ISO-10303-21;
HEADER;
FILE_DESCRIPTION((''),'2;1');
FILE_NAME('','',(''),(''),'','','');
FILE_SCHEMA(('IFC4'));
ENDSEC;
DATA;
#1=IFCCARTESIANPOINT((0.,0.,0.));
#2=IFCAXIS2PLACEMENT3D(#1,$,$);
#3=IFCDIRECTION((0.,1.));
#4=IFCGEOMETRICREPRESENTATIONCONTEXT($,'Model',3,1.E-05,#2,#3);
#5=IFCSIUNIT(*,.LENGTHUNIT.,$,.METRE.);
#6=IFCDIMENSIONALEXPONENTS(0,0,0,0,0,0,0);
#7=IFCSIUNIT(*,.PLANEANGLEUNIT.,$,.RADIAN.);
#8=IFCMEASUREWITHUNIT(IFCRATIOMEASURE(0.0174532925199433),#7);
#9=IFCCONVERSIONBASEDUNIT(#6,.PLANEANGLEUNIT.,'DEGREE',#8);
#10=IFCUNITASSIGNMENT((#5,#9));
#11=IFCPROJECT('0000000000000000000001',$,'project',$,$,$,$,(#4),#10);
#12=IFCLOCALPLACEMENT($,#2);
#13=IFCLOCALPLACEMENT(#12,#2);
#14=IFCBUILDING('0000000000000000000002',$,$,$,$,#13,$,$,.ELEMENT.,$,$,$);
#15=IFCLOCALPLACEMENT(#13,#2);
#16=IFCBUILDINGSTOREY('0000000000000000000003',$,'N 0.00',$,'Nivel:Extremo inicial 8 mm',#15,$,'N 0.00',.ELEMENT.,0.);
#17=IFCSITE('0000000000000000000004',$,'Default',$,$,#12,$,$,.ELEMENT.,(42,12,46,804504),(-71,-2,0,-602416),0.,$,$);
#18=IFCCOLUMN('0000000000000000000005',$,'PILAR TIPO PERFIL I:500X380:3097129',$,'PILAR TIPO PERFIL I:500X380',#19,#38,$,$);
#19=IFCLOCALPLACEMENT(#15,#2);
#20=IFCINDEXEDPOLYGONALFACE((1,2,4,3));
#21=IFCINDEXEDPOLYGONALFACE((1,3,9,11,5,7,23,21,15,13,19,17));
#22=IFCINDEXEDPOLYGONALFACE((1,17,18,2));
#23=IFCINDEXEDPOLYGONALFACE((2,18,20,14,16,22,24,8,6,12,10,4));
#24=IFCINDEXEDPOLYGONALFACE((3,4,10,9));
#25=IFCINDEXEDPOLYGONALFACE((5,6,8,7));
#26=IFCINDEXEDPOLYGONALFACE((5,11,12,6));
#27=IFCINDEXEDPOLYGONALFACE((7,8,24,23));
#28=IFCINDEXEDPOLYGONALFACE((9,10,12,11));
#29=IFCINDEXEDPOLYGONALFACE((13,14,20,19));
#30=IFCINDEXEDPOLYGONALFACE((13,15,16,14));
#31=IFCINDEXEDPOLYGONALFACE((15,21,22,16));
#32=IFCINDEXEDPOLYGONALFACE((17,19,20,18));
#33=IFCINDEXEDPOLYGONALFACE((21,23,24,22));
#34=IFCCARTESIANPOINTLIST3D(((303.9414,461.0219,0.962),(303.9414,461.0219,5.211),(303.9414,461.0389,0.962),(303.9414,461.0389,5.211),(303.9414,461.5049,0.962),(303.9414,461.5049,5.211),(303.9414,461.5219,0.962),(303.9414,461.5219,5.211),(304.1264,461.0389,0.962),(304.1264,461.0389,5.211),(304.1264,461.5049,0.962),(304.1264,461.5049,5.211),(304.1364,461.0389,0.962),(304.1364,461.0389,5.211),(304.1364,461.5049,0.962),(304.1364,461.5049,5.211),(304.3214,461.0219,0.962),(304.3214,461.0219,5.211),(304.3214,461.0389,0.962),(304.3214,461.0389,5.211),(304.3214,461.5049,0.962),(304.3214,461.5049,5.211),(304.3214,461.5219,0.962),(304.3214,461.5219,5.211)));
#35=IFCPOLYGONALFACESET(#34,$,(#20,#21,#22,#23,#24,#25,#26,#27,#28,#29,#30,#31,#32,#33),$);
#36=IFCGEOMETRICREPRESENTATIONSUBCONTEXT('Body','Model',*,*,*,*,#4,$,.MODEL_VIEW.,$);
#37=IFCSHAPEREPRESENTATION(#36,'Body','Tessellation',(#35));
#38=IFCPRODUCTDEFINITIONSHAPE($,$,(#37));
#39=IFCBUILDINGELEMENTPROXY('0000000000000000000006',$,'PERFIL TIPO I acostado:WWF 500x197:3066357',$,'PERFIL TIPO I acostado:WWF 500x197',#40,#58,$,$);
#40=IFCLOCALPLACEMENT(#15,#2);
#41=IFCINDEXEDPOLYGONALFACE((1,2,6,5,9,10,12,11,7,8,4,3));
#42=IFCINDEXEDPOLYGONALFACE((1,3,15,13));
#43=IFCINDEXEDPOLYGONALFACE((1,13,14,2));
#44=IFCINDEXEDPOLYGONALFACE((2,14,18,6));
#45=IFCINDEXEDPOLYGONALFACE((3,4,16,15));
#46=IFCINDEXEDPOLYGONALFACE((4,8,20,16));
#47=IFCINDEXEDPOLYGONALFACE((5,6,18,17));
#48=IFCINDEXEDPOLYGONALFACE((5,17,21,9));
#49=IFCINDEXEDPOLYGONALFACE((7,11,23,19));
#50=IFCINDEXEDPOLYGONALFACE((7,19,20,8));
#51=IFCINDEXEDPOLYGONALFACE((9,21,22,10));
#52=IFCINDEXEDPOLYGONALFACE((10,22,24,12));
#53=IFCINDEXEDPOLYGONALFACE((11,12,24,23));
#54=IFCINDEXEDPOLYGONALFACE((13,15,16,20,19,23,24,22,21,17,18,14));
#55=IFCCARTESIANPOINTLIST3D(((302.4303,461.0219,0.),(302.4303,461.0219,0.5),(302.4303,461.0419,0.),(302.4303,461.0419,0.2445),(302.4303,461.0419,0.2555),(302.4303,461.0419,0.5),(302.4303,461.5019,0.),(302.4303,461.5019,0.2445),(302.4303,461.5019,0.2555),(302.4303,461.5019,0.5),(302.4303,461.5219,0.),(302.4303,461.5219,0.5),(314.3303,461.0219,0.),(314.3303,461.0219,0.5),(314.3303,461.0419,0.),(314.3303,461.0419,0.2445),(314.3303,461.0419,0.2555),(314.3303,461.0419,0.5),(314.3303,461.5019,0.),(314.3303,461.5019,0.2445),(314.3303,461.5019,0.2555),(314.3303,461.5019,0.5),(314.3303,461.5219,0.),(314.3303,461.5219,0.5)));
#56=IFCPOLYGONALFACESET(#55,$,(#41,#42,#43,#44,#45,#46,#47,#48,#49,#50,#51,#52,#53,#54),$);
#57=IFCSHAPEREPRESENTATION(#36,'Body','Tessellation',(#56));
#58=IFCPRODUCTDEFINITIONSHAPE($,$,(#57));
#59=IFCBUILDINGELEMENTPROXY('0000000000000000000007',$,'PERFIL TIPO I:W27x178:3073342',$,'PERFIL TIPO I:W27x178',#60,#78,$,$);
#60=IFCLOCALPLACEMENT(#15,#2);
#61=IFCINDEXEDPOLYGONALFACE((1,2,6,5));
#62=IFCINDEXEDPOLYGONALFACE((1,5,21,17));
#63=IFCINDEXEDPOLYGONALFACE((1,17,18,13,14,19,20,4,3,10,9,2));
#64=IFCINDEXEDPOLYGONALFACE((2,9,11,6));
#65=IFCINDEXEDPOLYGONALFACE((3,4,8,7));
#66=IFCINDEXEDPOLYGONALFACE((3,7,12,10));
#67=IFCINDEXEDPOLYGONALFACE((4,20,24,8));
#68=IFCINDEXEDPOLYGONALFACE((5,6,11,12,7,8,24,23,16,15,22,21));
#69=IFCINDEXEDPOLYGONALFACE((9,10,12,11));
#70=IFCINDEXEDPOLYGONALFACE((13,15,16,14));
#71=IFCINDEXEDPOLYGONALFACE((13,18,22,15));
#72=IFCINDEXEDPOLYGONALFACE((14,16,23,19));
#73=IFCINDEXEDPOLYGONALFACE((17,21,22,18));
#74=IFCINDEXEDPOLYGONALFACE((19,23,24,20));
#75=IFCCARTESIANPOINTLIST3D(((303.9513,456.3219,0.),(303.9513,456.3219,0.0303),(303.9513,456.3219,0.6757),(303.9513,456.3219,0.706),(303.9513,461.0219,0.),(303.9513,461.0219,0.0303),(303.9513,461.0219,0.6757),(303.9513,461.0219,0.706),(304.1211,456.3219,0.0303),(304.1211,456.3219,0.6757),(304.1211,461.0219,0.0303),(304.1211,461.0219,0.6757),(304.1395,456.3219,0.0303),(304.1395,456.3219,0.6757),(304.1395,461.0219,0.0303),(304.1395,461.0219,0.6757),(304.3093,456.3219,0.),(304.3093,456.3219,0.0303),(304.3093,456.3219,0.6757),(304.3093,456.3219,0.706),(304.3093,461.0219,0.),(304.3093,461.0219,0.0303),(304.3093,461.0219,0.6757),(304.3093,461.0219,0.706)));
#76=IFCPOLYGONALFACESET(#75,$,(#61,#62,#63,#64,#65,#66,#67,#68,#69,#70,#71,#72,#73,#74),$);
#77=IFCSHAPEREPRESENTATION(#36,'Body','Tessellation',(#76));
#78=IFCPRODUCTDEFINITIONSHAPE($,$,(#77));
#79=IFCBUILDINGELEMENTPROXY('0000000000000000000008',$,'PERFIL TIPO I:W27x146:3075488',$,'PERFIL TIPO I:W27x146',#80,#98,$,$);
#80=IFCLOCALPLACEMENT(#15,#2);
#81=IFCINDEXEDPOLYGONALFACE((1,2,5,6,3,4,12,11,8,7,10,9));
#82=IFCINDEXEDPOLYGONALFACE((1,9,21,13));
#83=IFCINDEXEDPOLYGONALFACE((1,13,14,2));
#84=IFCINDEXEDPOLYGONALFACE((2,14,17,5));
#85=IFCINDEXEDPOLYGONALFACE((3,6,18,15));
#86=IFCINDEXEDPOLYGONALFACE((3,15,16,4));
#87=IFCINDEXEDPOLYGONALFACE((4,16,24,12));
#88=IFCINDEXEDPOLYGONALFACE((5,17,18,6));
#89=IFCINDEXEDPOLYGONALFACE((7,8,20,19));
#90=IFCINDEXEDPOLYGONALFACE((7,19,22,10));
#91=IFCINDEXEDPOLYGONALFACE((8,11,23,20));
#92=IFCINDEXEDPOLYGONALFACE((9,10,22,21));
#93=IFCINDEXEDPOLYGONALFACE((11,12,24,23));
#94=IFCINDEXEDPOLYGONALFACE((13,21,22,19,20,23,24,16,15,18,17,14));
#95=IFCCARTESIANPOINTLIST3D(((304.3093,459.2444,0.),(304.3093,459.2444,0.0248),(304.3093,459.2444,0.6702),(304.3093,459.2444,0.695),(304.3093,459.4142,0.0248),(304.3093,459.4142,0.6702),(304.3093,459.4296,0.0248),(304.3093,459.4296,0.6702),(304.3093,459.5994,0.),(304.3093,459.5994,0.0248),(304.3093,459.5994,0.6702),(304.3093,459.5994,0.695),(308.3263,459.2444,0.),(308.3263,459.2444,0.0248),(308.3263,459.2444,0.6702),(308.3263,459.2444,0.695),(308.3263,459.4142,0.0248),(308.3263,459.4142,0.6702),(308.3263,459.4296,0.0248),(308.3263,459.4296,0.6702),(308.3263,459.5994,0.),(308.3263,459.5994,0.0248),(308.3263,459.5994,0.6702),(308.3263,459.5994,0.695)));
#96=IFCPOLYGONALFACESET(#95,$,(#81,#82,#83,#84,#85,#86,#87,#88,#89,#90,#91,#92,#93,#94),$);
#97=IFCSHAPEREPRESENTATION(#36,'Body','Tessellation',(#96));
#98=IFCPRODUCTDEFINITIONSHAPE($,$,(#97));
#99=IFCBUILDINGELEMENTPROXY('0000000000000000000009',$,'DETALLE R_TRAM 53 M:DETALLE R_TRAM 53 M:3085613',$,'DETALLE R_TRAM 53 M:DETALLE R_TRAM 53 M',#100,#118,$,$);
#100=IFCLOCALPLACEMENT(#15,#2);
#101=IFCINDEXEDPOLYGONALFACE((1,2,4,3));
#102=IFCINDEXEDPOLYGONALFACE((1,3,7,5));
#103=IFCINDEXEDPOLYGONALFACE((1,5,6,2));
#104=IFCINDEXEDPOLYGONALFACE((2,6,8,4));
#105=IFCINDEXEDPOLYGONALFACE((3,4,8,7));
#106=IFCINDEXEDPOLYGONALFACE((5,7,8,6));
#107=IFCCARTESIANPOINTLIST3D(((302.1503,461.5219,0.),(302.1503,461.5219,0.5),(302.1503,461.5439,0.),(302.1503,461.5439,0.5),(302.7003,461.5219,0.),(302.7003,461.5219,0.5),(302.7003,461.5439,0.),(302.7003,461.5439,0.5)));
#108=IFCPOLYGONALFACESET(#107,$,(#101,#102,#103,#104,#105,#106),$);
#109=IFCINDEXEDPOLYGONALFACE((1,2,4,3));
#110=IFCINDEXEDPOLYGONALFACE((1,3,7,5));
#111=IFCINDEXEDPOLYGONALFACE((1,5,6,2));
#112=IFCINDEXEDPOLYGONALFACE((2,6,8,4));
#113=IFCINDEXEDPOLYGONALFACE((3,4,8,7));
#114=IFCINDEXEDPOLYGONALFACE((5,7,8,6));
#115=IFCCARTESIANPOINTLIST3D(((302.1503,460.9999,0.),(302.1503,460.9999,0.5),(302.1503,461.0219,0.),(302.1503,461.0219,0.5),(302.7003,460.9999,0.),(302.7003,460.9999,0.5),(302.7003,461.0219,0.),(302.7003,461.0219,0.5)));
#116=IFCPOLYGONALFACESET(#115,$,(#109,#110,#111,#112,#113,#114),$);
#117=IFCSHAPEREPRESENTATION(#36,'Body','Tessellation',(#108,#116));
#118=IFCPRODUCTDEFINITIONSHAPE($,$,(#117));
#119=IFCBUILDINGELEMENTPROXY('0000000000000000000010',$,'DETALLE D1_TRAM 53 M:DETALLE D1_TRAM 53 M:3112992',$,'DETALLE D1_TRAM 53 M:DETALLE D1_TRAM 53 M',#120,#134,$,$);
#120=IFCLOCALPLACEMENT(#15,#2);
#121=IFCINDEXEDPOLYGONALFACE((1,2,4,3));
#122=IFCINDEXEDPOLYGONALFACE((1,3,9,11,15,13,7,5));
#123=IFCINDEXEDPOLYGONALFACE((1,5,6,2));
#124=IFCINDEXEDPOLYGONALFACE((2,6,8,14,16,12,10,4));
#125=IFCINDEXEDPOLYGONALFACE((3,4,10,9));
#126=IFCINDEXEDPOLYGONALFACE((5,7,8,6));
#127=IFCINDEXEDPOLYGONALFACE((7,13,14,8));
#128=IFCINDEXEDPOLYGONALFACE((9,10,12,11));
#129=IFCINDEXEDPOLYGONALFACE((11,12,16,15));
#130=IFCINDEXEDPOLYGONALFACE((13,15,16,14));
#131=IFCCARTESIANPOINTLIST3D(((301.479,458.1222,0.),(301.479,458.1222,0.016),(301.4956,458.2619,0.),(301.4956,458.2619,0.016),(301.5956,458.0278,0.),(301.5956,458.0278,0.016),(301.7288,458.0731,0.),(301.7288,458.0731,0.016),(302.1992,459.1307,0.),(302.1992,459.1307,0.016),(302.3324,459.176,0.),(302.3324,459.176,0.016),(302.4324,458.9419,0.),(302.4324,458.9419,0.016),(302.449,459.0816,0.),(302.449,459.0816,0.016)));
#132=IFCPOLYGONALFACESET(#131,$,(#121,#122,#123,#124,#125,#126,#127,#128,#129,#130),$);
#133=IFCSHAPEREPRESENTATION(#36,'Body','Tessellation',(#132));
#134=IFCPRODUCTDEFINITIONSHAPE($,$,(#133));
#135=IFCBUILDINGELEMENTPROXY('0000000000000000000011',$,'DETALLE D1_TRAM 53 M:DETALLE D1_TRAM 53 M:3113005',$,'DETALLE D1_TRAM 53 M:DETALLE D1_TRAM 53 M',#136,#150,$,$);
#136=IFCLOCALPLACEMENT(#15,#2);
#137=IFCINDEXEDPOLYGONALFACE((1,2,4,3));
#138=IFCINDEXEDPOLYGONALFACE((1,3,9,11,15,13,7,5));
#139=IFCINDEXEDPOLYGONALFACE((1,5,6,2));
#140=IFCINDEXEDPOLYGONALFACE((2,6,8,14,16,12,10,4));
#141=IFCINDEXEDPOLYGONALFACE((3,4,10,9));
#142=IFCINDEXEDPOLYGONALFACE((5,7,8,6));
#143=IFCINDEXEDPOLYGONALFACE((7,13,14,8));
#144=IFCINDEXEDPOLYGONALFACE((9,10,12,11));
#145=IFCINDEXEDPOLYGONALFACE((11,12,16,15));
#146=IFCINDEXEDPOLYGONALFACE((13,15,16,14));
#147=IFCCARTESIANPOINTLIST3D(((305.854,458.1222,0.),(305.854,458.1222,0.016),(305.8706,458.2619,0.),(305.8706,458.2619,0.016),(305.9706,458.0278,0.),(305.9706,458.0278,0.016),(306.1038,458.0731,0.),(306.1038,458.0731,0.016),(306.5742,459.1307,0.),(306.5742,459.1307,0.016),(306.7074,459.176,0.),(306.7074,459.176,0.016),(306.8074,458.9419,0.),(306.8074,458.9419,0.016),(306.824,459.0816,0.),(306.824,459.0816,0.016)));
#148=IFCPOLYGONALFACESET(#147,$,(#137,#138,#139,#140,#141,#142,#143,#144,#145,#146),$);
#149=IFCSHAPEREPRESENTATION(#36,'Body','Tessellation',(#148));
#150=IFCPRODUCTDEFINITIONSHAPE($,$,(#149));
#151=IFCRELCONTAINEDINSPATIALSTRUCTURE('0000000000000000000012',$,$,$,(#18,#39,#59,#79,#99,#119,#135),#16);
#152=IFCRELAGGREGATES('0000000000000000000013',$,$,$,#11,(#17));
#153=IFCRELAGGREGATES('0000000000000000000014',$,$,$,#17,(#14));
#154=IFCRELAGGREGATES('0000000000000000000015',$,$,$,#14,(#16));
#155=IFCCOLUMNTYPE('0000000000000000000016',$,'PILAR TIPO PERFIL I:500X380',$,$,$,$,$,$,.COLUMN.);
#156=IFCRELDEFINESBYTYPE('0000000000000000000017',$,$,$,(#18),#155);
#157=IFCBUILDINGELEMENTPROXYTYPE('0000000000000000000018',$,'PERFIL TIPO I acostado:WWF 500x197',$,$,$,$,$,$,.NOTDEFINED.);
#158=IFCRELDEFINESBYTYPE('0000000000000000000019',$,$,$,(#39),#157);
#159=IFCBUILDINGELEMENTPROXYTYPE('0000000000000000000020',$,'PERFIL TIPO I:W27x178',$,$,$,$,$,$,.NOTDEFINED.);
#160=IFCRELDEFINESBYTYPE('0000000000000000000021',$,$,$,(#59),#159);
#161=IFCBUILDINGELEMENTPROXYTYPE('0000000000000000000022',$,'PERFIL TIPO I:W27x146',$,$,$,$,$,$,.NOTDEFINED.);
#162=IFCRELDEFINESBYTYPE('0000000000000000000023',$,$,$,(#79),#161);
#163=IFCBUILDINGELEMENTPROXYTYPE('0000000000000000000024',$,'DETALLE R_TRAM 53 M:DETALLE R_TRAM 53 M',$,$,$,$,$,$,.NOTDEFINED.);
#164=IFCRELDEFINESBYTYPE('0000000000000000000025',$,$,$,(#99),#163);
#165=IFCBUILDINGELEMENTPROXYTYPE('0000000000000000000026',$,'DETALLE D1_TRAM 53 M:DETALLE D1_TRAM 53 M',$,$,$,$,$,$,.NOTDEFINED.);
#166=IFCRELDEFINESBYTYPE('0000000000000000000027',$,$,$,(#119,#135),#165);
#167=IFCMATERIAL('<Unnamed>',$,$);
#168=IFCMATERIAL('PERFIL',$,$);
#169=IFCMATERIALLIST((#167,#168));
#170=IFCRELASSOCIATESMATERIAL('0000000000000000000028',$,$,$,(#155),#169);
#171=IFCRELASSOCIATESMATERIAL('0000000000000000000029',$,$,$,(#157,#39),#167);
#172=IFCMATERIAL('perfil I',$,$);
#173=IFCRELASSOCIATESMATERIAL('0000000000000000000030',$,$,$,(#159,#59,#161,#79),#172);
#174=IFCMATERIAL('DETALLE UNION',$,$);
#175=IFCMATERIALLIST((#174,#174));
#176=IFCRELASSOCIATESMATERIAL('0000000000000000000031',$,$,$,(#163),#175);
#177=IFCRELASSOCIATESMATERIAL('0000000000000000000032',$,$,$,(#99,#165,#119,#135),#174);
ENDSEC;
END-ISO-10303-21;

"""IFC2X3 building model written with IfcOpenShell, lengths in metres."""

from ifc_helpers import new_model, entity, si_unit, converted_unit, direction, frame, frame_2d, origin, place, context, subcontext, project, spatial, polyline, rectangle, i_section, outline, extrude, source, transform, mapped, material, material_list, type_object, type_shapes, element, save


model = new_model("IFC2X3")

# Units and contexts
model_context = context("Model", 3, precision=1e-05, world=origin(), true_north=direction((0.0, 1.0)))
body_context = subcontext(model_context, "Body", "Model", "MODEL_VIEW")
ifc_project = project(units=[si_unit("LENGTHUNIT", "METRE"), converted_unit("PLANEANGLEUNIT", "DEGREE", entity("IfcRatioMeasure", 0.0174532925199433), si_unit("PLANEANGLEUNIT", "RADIAN"), dimensions=[0, 0, 0, 0, 0, 0, 0])], contexts=[model_context])

# Site, building, storey
site_placement = place(None, origin())
site = spatial("IfcSite", under=ifc_project, at=site_placement, Name="Default", CompositionType="ELEMENT", RefLatitude=(42, 12, 46, 804504), RefLongitude=(-71, -2, 0, -602416), RefElevation=0.0)
building_placement = place(site_placement, origin())
building = spatial("IfcBuilding", under=site, at=building_placement, CompositionType="ELEMENT")
storey_placement = place(building_placement, origin())
storey = spatial("IfcBuildingStorey", under=building, at=storey_placement, Name="N 0.00", ObjectType="Nivel:Extremo inicial 8 mm", LongName="N 0.00", CompositionType="ELEMENT", Elevation=0.0)

# Column
ifc_material_1 = material(Name="<Unnamed>")
ifc_material_2 = material(Name="PERFIL")
ifc_material_list_1 = material_list([ifc_material_1, ifc_material_2])
column_type = type_object("IfcColumnType", Name="PILAR TIPO PERFIL I:500X380", PredefinedType="COLUMN", material=ifc_material_list_1)
shared_shape_1 = source(origin(), body_context, "Body", "SweptSolid", [
    extrude(i_section(OverallWidth=0.38, OverallDepth=0.5, WebThickness=0.01, FlangeThickness=0.017, at=frame_2d((0.0, 0.0), x_axis=(1.0, 0.0))), frame((0.0, 0.0, 0.962), z_axis=(0.0, 0.0, 1.0), x_axis=(0.0, -1.0, 0.0)), (0.0, 0.0, 1.0), 4.249),
])
type_shapes(column_type, [shared_shape_1])
column_placement = place(storey_placement, frame((304.1314, 461.2719, 0.0), z_axis=(0.0, 0.0, 1.0), x_axis=(0.0, -1.0, 0.0)))
element("IfcColumn", 1, at=column_placement, inside=storey, type_object=column_type, Name="PILAR TIPO PERFIL I:500X380:3097129", ObjectType="PILAR TIPO PERFIL I:500X380", context=body_context, shape_type="MappedRepresentation", body=[
    mapped(shared_shape_1, transform((0.0, 0.0, 0.0), scale=1.0)),
])

# Building element proxies
building_element_proxy_type_1 = type_object("IfcBuildingElementProxyType", Name="PERFIL TIPO I acostado:WWF 500x197", PredefinedType="NOTDEFINED", material=ifc_material_1)
shared_shape_2 = source(origin(), body_context, "Body", "SweptSolid", [
    extrude(outline(polyline([(-0.25, -0.23), (-0.25, -0.25), (0.25, -0.25), (0.25, -0.23), (0.0055, -0.23), (0.0055, 0.23), (0.25, 0.23), (0.25, 0.25), (-0.25, 0.25), (-0.25, 0.23), (-0.0055, 0.23), (-0.0055, -0.23), (-0.25, -0.23)])), frame((0.0, 0.0, 0.25), z_axis=(-1.0, 0.0, 0.0), x_axis=(0.0, 0.0, -1.0)), (0.0, 0.0, -1.0), 11.9),
])
type_shapes(building_element_proxy_type_1, [shared_shape_2])
proxy_1_placement = place(storey_placement, frame((302.4303, 461.2719, 0.0)))
element("IfcBuildingElementProxy", 2, at=proxy_1_placement, inside=storey, type_object=building_element_proxy_type_1, material=ifc_material_1, Name="PERFIL TIPO I acostado:WWF 500x197:3066357", ObjectType="PERFIL TIPO I acostado:WWF 500x197", context=body_context, shape_type="MappedRepresentation", body=[
    mapped(shared_shape_2, transform((0.0, 0.0, 0.0), scale=1.0)),
])
ifc_material_3 = material(Name="perfil I")
building_element_proxy_type_2 = type_object("IfcBuildingElementProxyType", Name="PERFIL TIPO I:W27x178", PredefinedType="NOTDEFINED", material=ifc_material_3)
shared_shape_3 = source(origin(), body_context, "Body", "SweptSolid", [
    extrude(outline(polyline([(0.3227, -0.179), (0.353, -0.179), (0.353, 0.179), (0.3227, 0.179), (0.3227, 0.0092), (-0.3227, 0.0092), (-0.3227, 0.179), (-0.353, 0.179), (-0.353, -0.179), (-0.3227, -0.179), (-0.3227, -0.0092), (0.3227, -0.0092), (0.3227, -0.179)])), frame((0.0, 0.0, 0.353), z_axis=(1.0, 0.0, 0.0), x_axis=(0.0, 0.0, 1.0)), (0.0, 0.0, 1.0), 4.7),
])
type_shapes(building_element_proxy_type_2, [shared_shape_3])
proxy_2_placement = place(storey_placement, frame((304.1303, 461.0219, 0.0), z_axis=(0.0, 0.0, 1.0), x_axis=(0.0, -1.0, 0.0)))
element("IfcBuildingElementProxy", 3, at=proxy_2_placement, inside=storey, type_object=building_element_proxy_type_2, material=ifc_material_3, Name="PERFIL TIPO I:W27x178:3073342", ObjectType="PERFIL TIPO I:W27x178", context=body_context, shape_type="MappedRepresentation", body=[
    mapped(shared_shape_3, transform((0.0, 0.0, 0.0), scale=1.0)),
])
building_element_proxy_type_3 = type_object("IfcBuildingElementProxyType", Name="PERFIL TIPO I:W27x146", PredefinedType="NOTDEFINED", material=ifc_material_3)
shared_shape_4 = source(origin(), body_context, "Body", "SweptSolid", [
    extrude(outline(polyline([(0.3227, -0.1775), (0.3475, -0.1775), (0.3475, 0.1775), (0.3227, 0.1775), (0.3227, 0.0077), (-0.3227, 0.0077), (-0.3227, 0.1775), (-0.3475, 0.1775), (-0.3475, -0.1775), (-0.3227, -0.1775), (-0.3227, -0.0077), (0.3227, -0.0077), (0.3227, -0.1775)])), frame((0.0, 0.0, 0.3475), z_axis=(1.0, 0.0, 0.0), x_axis=(0.0, 0.0, 1.0)), (0.0, 0.0, 1.0), 4.017),
])
type_shapes(building_element_proxy_type_3, [shared_shape_4])
proxy_3_placement = place(storey_placement, frame((304.3093, 459.4219, 0.0)))
element("IfcBuildingElementProxy", 4, at=proxy_3_placement, inside=storey, type_object=building_element_proxy_type_3, material=ifc_material_3, Name="PERFIL TIPO I:W27x146:3075488", ObjectType="PERFIL TIPO I:W27x146", context=body_context, shape_type="MappedRepresentation", body=[
    mapped(shared_shape_4, transform((0.0, 0.0, 0.0), scale=1.0)),
])
ifc_material_4 = material(Name="DETALLE UNION")
ifc_material_list_2 = material_list([ifc_material_4, ifc_material_4])
building_element_proxy_type_4 = type_object("IfcBuildingElementProxyType", Name="DETALLE R_TRAM 53 M:DETALLE R_TRAM 53 M", PredefinedType="NOTDEFINED", material=ifc_material_list_2)
shared_shape_5 = source(origin(), body_context, "Body", "SweptSolid", [
    extrude(rectangle(XDim=0.55, YDim=0.022, at=frame_2d((0.0, 0.0), x_axis=(1.0, 0.0))), frame((0.275, 0.011, 0.0), z_axis=(0.0, 0.0, 1.0), x_axis=(-1.0, 0.0, 0.0)), (0.0, 0.0, 1.0), 0.5),
    extrude(rectangle(XDim=0.55, YDim=0.022, at=frame_2d((0.0, 0.0), x_axis=(1.0, 0.0))), frame((0.275, -0.511, 0.0), z_axis=(0.0, 0.0, 1.0), x_axis=(-1.0, 0.0, 0.0)), (0.0, 0.0, 1.0), 0.5),
])
type_shapes(building_element_proxy_type_4, [shared_shape_5])
proxy_4_placement = place(storey_placement, frame((302.1503, 461.5219, 0.0)))
element("IfcBuildingElementProxy", 5, at=proxy_4_placement, inside=storey, type_object=building_element_proxy_type_4, material=ifc_material_4, Name="DETALLE R_TRAM 53 M:DETALLE R_TRAM 53 M:3085613", ObjectType="DETALLE R_TRAM 53 M:DETALLE R_TRAM 53 M", context=body_context, shape_type="MappedRepresentation", body=[
    mapped(shared_shape_5, transform((0.0, 0.0, 0.0), scale=1.0)),
])
building_element_proxy_type_5 = type_object("IfcBuildingElementProxyType", Name="DETALLE D1_TRAM 53 M:DETALLE D1_TRAM 53 M", PredefinedType="NOTDEFINED", material=ifc_material_4)
shared_shape_6 = source(origin(), body_context, "Body", "SweptSolid", [
    extrude(outline(polyline([(-0.075, -0.678), (0.075, -0.678), (0.15, -0.559), (0.15, 0.559), (0.075, 0.678), (-0.075, 0.678), (-0.15, 0.559), (-0.15, -0.559), (-0.075, -0.678)])), frame((0.0, 0.0, 0.0), z_axis=(0.0, 0.0, 1.0), x_axis=(-0.777146, 0.62932, 0.0)), (0.0, 0.0, 1.0), 0.016),
])
type_shapes(building_element_proxy_type_5, [shared_shape_6])
for number, where, name in (
    (6, (301.964, 458.6019, 0.0), "DETALLE D1_TRAM 53 M:DETALLE D1_TRAM 53 M:3112992"),
    (7, (306.339, 458.6019, 0.0), "DETALLE D1_TRAM 53 M:DETALLE D1_TRAM 53 M:3113005"),
):
    element("IfcBuildingElementProxy", number, at=place(storey_placement, frame(where)), inside=storey, type_object=building_element_proxy_type_5, material=ifc_material_4, Name=name, ObjectType="DETALLE D1_TRAM 53 M:DETALLE D1_TRAM 53 M", context=body_context, shape_type="MappedRepresentation", body=[
        mapped(shared_shape_6, transform((0.0, 0.0, 0.0), scale=1.0)),
    ])

save(model, "model.ifc")
